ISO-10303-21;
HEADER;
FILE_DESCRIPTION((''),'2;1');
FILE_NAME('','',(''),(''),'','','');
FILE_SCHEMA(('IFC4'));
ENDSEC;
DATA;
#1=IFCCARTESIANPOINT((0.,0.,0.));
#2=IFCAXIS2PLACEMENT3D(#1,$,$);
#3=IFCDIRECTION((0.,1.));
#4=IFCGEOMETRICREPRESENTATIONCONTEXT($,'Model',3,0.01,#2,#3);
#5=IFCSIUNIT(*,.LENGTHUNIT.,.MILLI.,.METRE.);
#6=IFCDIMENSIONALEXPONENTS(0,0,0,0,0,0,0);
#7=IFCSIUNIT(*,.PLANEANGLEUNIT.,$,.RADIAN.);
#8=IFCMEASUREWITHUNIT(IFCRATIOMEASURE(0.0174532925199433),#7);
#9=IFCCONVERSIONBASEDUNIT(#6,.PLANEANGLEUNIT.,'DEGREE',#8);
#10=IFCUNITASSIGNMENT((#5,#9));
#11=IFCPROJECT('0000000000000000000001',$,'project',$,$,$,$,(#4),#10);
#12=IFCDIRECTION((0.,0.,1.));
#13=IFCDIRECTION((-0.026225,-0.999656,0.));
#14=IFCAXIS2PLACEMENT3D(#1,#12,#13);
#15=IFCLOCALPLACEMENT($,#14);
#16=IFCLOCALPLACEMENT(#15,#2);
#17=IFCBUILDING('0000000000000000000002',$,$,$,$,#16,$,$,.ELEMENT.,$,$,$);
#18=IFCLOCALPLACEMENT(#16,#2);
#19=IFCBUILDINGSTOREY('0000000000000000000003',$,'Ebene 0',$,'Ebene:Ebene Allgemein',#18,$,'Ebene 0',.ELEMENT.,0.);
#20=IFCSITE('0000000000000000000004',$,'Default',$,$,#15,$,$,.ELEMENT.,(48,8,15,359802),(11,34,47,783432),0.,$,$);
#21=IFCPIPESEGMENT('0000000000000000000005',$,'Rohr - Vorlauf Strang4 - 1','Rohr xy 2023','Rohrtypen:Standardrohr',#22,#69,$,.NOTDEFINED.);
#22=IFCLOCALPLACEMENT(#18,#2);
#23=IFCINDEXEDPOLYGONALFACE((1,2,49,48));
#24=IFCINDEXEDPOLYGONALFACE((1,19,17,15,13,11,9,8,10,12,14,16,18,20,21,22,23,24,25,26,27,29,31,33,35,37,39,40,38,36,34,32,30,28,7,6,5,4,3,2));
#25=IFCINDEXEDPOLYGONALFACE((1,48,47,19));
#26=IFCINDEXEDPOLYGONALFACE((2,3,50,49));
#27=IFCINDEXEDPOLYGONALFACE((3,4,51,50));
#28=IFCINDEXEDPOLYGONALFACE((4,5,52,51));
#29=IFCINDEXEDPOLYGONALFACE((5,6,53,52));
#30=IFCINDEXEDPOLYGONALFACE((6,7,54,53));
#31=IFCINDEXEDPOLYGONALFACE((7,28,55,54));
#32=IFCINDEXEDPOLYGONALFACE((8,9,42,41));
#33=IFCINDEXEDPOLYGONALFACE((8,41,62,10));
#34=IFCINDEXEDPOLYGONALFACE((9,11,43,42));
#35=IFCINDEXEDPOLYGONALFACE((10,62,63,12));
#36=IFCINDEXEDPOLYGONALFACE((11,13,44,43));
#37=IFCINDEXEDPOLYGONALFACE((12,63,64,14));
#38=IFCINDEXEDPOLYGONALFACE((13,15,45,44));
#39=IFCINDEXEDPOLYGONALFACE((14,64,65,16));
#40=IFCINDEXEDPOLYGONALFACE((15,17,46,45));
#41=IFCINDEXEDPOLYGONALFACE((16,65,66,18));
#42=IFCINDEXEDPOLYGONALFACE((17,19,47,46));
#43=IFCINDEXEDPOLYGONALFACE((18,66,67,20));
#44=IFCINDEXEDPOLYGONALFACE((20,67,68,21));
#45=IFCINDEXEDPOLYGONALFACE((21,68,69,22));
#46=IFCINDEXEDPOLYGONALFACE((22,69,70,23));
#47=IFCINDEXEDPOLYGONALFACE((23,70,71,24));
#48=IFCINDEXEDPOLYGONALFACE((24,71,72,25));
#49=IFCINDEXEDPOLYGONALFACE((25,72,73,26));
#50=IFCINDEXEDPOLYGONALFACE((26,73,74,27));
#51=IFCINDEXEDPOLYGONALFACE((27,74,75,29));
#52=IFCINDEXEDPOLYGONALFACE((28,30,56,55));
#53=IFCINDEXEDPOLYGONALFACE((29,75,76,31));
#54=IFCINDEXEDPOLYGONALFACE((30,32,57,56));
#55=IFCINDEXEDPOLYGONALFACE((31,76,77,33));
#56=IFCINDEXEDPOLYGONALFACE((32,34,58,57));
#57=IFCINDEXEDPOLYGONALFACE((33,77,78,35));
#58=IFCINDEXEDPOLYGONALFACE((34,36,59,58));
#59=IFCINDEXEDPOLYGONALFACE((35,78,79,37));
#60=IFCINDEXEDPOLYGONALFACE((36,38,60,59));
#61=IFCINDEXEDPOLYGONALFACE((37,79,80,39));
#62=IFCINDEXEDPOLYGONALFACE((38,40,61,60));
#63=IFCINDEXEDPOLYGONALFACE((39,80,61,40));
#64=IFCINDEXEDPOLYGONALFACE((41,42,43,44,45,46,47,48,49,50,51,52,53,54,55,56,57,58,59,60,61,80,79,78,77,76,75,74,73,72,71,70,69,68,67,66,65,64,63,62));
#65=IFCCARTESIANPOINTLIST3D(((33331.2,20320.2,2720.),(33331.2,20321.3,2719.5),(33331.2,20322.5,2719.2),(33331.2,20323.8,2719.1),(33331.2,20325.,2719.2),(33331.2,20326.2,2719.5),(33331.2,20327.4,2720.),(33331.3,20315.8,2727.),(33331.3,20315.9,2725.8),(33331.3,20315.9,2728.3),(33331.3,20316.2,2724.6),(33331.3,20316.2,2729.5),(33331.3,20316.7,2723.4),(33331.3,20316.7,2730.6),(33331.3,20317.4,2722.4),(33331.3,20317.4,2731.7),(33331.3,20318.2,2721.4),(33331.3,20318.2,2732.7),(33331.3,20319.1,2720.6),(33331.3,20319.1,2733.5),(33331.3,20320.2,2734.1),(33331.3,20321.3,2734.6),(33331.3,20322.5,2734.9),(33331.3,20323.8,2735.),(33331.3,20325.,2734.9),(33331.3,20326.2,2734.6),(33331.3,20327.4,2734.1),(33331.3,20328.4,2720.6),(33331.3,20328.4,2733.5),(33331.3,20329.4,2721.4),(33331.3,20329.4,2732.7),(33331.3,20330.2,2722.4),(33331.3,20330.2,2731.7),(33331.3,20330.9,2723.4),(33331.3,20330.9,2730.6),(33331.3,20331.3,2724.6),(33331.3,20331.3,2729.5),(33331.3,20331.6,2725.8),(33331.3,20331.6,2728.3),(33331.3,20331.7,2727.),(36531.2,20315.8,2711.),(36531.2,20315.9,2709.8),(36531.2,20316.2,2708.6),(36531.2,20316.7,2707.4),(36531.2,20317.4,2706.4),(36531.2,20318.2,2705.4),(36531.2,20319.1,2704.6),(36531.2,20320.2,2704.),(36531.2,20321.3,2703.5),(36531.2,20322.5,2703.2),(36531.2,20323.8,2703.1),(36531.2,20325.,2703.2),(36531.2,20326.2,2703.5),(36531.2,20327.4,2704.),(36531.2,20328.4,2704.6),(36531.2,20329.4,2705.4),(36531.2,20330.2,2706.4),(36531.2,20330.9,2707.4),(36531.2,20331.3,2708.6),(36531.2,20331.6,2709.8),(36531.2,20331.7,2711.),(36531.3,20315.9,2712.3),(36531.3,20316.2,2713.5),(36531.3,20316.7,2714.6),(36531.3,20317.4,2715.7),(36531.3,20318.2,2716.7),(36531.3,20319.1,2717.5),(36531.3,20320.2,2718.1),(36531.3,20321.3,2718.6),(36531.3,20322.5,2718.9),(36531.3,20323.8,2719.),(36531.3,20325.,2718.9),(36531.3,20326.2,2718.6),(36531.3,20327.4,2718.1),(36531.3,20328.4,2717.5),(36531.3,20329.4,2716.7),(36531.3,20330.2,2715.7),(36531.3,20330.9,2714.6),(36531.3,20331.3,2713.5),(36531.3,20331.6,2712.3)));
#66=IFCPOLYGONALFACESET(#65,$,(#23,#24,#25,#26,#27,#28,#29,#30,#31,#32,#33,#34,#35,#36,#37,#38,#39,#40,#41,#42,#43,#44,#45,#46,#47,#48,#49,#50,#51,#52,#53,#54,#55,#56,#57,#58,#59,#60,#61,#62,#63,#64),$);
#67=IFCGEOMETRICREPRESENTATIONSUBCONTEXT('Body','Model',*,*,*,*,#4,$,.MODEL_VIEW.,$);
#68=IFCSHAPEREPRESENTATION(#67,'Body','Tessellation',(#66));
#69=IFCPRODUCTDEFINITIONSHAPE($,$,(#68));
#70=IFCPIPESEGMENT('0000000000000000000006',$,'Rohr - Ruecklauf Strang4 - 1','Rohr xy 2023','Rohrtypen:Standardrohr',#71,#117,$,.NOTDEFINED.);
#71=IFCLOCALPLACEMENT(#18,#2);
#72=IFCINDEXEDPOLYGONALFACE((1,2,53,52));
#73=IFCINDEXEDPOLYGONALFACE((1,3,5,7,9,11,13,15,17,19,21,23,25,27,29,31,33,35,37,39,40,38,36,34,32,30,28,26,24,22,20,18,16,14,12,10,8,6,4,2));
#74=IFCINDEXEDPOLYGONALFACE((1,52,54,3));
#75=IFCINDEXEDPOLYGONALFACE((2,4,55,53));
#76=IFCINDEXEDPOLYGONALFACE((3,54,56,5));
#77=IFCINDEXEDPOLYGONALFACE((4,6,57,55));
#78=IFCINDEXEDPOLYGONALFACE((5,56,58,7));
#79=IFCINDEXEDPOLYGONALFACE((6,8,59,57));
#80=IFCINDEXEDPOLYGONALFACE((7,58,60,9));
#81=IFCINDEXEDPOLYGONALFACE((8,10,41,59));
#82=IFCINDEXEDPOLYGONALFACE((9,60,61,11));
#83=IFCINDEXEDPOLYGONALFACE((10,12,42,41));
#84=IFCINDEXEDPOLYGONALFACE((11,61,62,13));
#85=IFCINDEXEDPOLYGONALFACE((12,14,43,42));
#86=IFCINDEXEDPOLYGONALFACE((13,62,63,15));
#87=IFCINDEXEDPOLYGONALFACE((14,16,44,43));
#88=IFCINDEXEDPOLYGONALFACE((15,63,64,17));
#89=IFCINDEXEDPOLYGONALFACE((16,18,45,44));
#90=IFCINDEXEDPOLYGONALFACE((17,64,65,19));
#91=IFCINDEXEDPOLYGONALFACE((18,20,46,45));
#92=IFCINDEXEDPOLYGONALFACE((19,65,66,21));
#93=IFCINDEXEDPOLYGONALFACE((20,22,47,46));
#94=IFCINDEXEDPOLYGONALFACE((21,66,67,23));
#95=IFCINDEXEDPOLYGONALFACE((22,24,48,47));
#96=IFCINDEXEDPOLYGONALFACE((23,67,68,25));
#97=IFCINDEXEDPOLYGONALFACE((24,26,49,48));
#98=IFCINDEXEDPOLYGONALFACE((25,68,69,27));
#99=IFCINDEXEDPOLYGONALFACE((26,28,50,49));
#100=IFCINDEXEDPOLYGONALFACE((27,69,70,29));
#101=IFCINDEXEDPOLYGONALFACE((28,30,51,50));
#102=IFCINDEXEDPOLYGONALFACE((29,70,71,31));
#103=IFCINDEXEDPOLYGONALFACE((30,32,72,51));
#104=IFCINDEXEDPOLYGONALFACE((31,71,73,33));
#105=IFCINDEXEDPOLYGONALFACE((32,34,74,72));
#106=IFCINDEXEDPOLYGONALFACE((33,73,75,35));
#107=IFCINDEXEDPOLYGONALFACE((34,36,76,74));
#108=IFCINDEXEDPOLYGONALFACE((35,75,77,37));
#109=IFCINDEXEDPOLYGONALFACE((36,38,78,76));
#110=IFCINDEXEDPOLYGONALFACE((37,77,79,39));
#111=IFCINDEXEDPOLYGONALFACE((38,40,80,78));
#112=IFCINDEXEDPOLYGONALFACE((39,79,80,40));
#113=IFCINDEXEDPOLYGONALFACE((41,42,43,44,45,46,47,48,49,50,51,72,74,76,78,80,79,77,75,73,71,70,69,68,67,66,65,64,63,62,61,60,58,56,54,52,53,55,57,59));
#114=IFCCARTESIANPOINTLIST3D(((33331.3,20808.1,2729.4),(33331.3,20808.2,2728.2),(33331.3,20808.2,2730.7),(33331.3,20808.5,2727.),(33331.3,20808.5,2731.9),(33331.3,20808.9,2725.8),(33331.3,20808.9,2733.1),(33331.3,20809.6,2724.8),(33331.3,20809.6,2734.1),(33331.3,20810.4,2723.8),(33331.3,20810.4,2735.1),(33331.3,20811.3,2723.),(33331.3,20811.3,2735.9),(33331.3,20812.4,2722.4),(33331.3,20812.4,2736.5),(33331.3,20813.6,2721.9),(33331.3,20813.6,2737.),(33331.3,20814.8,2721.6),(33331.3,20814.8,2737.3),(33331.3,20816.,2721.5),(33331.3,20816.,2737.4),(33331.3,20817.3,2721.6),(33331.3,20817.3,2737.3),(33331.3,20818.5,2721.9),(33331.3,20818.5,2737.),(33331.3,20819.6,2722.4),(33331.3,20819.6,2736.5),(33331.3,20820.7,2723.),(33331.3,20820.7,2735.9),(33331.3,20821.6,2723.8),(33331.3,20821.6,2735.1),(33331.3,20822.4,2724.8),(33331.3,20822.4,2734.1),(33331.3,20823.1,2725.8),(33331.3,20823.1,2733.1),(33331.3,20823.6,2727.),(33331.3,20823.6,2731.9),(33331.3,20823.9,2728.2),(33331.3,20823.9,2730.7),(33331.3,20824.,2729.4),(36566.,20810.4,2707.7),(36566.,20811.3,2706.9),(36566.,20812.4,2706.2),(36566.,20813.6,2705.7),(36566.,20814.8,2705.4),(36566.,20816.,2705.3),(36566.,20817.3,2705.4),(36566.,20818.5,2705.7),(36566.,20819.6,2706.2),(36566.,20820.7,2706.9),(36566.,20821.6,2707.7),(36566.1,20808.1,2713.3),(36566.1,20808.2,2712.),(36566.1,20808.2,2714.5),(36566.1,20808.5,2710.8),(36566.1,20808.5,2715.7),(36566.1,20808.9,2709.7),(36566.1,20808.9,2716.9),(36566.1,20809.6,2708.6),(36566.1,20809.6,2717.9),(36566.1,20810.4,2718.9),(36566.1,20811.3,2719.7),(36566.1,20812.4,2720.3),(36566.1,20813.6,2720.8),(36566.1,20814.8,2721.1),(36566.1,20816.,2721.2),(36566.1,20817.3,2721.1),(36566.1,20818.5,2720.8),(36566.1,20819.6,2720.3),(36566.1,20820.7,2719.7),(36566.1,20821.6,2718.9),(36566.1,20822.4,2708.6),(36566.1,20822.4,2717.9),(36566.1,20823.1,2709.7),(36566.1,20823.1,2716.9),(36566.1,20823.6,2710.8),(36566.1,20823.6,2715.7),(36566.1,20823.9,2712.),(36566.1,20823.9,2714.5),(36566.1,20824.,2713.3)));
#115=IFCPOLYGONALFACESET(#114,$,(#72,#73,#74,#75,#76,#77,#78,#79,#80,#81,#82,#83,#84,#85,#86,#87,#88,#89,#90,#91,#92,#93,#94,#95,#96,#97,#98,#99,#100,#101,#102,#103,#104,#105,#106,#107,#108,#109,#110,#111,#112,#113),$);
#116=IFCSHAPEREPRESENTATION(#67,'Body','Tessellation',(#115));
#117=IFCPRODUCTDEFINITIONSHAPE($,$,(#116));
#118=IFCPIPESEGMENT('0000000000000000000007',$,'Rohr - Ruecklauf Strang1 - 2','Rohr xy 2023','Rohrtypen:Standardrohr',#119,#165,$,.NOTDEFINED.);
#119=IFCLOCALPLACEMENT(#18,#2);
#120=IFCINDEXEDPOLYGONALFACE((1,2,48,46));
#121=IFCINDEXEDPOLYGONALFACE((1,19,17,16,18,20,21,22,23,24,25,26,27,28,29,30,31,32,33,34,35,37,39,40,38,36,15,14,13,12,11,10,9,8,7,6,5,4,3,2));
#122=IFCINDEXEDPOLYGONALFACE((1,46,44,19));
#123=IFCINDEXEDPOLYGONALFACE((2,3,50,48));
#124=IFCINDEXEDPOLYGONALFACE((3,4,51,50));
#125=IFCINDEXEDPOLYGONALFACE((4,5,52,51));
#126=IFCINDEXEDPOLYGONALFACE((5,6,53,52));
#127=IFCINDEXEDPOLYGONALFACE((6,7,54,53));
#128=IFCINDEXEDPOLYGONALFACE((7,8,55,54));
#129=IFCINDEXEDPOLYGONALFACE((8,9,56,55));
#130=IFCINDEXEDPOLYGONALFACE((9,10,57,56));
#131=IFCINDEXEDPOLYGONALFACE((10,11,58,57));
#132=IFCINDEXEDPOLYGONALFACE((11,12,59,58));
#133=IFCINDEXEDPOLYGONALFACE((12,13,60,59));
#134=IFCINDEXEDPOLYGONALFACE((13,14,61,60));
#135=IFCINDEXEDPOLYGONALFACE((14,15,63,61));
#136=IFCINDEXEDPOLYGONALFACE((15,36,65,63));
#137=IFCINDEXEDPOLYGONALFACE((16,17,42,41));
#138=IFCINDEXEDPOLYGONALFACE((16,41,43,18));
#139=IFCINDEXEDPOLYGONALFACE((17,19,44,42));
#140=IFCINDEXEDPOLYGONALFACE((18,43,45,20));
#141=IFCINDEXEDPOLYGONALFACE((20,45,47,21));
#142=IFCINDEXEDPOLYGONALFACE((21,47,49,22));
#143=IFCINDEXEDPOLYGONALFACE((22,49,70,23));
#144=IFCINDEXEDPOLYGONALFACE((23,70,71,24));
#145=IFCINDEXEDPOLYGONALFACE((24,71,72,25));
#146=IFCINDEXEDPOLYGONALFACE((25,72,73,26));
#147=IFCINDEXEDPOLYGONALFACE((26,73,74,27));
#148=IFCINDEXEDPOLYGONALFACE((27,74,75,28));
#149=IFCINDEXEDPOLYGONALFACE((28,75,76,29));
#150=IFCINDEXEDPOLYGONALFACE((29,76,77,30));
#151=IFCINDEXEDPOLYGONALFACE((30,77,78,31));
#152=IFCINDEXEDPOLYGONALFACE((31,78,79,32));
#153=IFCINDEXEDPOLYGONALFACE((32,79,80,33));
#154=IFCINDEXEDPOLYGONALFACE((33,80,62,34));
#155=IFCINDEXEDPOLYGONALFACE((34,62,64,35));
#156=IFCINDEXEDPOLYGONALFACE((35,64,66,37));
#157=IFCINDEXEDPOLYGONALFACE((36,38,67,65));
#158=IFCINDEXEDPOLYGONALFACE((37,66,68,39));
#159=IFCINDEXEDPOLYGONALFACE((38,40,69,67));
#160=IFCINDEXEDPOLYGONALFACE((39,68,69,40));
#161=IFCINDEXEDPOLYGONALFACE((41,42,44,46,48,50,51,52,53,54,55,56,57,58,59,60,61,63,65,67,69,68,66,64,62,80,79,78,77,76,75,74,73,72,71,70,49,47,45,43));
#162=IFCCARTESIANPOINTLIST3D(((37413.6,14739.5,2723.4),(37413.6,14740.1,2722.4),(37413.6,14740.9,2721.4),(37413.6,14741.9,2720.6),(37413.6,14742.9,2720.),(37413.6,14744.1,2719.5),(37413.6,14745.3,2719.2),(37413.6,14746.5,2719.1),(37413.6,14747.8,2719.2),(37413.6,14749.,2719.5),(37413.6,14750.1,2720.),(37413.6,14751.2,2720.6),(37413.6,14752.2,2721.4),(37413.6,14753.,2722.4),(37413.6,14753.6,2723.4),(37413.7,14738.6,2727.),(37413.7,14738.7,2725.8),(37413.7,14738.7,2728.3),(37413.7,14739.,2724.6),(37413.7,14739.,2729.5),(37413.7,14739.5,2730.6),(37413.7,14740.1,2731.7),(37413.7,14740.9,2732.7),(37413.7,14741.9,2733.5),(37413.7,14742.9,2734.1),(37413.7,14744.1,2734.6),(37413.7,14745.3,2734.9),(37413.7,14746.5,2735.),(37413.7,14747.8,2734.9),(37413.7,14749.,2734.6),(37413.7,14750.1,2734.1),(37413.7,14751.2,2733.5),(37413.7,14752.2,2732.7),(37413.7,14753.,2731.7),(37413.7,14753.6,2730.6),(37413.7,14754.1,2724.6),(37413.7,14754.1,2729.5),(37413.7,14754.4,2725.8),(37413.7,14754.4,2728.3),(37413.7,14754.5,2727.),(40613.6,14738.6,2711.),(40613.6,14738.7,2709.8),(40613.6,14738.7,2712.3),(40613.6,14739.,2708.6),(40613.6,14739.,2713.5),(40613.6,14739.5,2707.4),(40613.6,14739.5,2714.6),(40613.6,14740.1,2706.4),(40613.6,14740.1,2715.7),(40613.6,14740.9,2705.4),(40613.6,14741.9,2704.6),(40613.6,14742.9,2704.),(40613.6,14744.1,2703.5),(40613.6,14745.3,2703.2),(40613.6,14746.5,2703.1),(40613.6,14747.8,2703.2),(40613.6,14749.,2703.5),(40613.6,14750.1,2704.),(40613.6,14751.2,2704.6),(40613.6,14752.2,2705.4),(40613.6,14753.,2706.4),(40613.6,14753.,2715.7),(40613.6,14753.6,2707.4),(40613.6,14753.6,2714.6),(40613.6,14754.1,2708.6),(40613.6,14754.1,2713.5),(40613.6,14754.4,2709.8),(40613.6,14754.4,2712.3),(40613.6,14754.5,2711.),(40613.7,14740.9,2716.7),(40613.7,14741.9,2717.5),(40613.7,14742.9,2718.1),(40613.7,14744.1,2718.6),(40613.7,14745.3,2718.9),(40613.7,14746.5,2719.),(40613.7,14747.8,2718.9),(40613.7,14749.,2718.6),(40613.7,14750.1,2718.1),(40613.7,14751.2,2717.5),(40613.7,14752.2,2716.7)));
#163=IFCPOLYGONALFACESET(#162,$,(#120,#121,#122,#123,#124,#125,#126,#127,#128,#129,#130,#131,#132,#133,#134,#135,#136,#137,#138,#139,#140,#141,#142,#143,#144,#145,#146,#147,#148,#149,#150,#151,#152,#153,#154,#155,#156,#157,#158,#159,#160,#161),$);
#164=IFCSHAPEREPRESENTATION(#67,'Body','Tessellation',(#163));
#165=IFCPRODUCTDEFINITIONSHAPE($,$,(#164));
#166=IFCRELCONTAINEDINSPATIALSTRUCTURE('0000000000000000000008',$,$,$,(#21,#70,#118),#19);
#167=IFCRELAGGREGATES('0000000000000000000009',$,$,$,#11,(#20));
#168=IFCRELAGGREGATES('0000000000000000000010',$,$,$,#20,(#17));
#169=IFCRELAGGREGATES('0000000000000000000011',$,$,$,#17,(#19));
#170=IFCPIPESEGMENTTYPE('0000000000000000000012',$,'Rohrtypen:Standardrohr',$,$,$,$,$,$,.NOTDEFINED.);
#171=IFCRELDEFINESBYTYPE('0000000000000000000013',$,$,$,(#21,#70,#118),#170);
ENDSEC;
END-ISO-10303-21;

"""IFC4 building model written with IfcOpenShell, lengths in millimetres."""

from ifc_helpers import new_model, entity, si_unit, converted_unit, direction, frame, origin, place, context, subcontext, project, spatial, indexed_curve, outline, extrude, type_object, element, save


model = new_model("IFC4")

# Units and contexts
model_context = context("Model", 3, precision=0.01, world=origin(), true_north=direction((0.0, 1.0)))
body_context = subcontext(model_context, "Body", "Model", "MODEL_VIEW")
ifc_project = project(units=[si_unit("LENGTHUNIT", "METRE", prefix="MILLI"), converted_unit("PLANEANGLEUNIT", "DEGREE", entity("IfcRatioMeasure", 0.0174532925199433), si_unit("PLANEANGLEUNIT", "RADIAN"), dimensions=[0, 0, 0, 0, 0, 0, 0])], contexts=[model_context])

# Site, building, storey
site_placement = place(None, frame((0.0, 0.0, 0.0), z_axis=(0.0, 0.0, 1.0), x_axis=(-0.026225, -0.999656, 0.0)))
site = spatial("IfcSite", under=ifc_project, at=site_placement, Name="Default", CompositionType="ELEMENT", RefLatitude=(48, 8, 15, 359802), RefLongitude=(11, 34, 47, 783432), RefElevation=0.0)
building_placement = place(site_placement, origin())
building = spatial("IfcBuilding", under=site, at=building_placement, CompositionType="ELEMENT")
storey_placement = place(building_placement, origin())
storey = spatial("IfcBuildingStorey", under=building, at=storey_placement, Name="Ebene 0", ObjectType="Ebene:Ebene Allgemein", LongName="Ebene 0", CompositionType="ELEMENT", Elevation=0.0)

# Pipe segments
pipe_segment_type = type_object("IfcPipeSegmentType", Name="Rohrtypen:Standardrohr", PredefinedType="NOTDEFINED")
pipe_segment_1_placement = place(storey_placement, origin())
element("IfcPipeSegment", 1, at=pipe_segment_1_placement, inside=storey, type_object=pipe_segment_type, Name="Rohr - Vorlauf Strang4 - 1", Description="Rohr xy 2023", ObjectType="Rohrtypen:Standardrohr", PredefinedType="NOTDEFINED", context=body_context, shape_type="SweptSolid", body=[
    extrude(outline(indexed_curve([(7.9, 0.0), (7.8, 1.2), (7.6, 2.5), (7.1, 3.6), (6.4, 4.7), (5.6, 5.6), (4.7, 6.4), (3.6, 7.1), (2.5, 7.6), (1.2, 7.8), (0.0, 7.9), (-1.2, 7.8), (-2.5, 7.6), (-3.6, 7.1), (-4.7, 6.4), (-5.6, 5.6), (-6.4, 4.7), (-7.1, 3.6), (-7.6, 2.5), (-7.8, 1.2), (-7.9, 0.0), (-7.8, -1.2), (-7.6, -2.5), (-7.1, -3.6), (-6.4, -4.7), (-5.6, -5.6), (-4.7, -6.4), (-3.6, -7.1), (-2.5, -7.6), (-1.2, -7.8), (0.0, -7.9), (1.2, -7.8), (2.5, -7.6), (3.6, -7.1), (4.7, -6.4), (5.6, -5.6), (6.4, -4.7), (7.1, -3.6), (7.6, -2.5), (7.8, -1.2), (7.9, 0.0)], self_intersect=False)), frame((36531.2, 20323.8, 2711.0), z_axis=(-0.999988, 0.0, 0.005), x_axis=(0.0, 1.0, 0.0)), (0.0, 0.0, 1.0), 3200.0),
])
pipe_segment_2_placement = place(storey_placement, origin())
element("IfcPipeSegment", 2, at=pipe_segment_2_placement, inside=storey, type_object=pipe_segment_type, Name="Rohr - Ruecklauf Strang4 - 1", Description="Rohr xy 2023", ObjectType="Rohrtypen:Standardrohr", PredefinedType="NOTDEFINED", context=body_context, shape_type="SweptSolid", body=[
    extrude(outline(indexed_curve([(7.9, 0.0), (7.8, 1.2), (7.6, 2.5), (7.1, 3.6), (6.4, 4.7), (5.6, 5.6), (4.7, 6.4), (3.6, 7.1), (2.5, 7.6), (1.2, 7.8), (0.0, 7.9), (-1.2, 7.8), (-2.5, 7.6), (-3.6, 7.1), (-4.7, 6.4), (-5.6, 5.6), (-6.4, 4.7), (-7.1, 3.6), (-7.6, 2.5), (-7.8, 1.2), (-7.9, 0.0), (-7.8, -1.2), (-7.6, -2.5), (-7.1, -3.6), (-6.4, -4.7), (-5.6, -5.6), (-4.7, -6.4), (-3.6, -7.1), (-2.5, -7.6), (-1.2, -7.8), (0.0, -7.9), (1.2, -7.8), (2.5, -7.6), (3.6, -7.1), (4.7, -6.4), (5.6, -5.6), (6.4, -4.7), (7.1, -3.6), (7.6, -2.5), (7.8, -1.2), (7.9, 0.0)], self_intersect=False)), frame((36566.1, 20816.0, 2713.3), z_axis=(-0.999988, 0.0, 0.005), x_axis=(0.0, 1.0, 0.0)), (0.0, 0.0, 1.0), 3234.8),
])
pipe_segment_3_placement = place(storey_placement, origin())
element("IfcPipeSegment", 3, at=pipe_segment_3_placement, inside=storey, type_object=pipe_segment_type, Name="Rohr - Ruecklauf Strang1 - 2", Description="Rohr xy 2023", ObjectType="Rohrtypen:Standardrohr", PredefinedType="NOTDEFINED", context=body_context, shape_type="SweptSolid", body=[
    extrude(outline(indexed_curve([(7.9, 0.0), (7.8, 1.2), (7.6, 2.5), (7.1, 3.6), (6.4, 4.7), (5.6, 5.6), (4.7, 6.4), (3.6, 7.1), (2.5, 7.6), (1.2, 7.8), (0.0, 7.9), (-1.2, 7.8), (-2.5, 7.6), (-3.6, 7.1), (-4.7, 6.4), (-5.6, 5.6), (-6.4, 4.7), (-7.1, 3.6), (-7.6, 2.5), (-7.8, 1.2), (-7.9, 0.0), (-7.8, -1.2), (-7.6, -2.5), (-7.1, -3.6), (-6.4, -4.7), (-5.6, -5.6), (-4.7, -6.4), (-3.6, -7.1), (-2.5, -7.6), (-1.2, -7.8), (0.0, -7.9), (1.2, -7.8), (2.5, -7.6), (3.6, -7.1), (4.7, -6.4), (5.6, -5.6), (6.4, -4.7), (7.1, -3.6), (7.6, -2.5), (7.8, -1.2), (7.9, 0.0)], self_intersect=False)), frame((40613.6, 14746.5, 2711.0), z_axis=(-0.999988, 0.0, 0.005), x_axis=(0.0, 1.0, 0.0)), (0.0, 0.0, 1.0), 3200.0),
])

save(model, "model.ifc")
